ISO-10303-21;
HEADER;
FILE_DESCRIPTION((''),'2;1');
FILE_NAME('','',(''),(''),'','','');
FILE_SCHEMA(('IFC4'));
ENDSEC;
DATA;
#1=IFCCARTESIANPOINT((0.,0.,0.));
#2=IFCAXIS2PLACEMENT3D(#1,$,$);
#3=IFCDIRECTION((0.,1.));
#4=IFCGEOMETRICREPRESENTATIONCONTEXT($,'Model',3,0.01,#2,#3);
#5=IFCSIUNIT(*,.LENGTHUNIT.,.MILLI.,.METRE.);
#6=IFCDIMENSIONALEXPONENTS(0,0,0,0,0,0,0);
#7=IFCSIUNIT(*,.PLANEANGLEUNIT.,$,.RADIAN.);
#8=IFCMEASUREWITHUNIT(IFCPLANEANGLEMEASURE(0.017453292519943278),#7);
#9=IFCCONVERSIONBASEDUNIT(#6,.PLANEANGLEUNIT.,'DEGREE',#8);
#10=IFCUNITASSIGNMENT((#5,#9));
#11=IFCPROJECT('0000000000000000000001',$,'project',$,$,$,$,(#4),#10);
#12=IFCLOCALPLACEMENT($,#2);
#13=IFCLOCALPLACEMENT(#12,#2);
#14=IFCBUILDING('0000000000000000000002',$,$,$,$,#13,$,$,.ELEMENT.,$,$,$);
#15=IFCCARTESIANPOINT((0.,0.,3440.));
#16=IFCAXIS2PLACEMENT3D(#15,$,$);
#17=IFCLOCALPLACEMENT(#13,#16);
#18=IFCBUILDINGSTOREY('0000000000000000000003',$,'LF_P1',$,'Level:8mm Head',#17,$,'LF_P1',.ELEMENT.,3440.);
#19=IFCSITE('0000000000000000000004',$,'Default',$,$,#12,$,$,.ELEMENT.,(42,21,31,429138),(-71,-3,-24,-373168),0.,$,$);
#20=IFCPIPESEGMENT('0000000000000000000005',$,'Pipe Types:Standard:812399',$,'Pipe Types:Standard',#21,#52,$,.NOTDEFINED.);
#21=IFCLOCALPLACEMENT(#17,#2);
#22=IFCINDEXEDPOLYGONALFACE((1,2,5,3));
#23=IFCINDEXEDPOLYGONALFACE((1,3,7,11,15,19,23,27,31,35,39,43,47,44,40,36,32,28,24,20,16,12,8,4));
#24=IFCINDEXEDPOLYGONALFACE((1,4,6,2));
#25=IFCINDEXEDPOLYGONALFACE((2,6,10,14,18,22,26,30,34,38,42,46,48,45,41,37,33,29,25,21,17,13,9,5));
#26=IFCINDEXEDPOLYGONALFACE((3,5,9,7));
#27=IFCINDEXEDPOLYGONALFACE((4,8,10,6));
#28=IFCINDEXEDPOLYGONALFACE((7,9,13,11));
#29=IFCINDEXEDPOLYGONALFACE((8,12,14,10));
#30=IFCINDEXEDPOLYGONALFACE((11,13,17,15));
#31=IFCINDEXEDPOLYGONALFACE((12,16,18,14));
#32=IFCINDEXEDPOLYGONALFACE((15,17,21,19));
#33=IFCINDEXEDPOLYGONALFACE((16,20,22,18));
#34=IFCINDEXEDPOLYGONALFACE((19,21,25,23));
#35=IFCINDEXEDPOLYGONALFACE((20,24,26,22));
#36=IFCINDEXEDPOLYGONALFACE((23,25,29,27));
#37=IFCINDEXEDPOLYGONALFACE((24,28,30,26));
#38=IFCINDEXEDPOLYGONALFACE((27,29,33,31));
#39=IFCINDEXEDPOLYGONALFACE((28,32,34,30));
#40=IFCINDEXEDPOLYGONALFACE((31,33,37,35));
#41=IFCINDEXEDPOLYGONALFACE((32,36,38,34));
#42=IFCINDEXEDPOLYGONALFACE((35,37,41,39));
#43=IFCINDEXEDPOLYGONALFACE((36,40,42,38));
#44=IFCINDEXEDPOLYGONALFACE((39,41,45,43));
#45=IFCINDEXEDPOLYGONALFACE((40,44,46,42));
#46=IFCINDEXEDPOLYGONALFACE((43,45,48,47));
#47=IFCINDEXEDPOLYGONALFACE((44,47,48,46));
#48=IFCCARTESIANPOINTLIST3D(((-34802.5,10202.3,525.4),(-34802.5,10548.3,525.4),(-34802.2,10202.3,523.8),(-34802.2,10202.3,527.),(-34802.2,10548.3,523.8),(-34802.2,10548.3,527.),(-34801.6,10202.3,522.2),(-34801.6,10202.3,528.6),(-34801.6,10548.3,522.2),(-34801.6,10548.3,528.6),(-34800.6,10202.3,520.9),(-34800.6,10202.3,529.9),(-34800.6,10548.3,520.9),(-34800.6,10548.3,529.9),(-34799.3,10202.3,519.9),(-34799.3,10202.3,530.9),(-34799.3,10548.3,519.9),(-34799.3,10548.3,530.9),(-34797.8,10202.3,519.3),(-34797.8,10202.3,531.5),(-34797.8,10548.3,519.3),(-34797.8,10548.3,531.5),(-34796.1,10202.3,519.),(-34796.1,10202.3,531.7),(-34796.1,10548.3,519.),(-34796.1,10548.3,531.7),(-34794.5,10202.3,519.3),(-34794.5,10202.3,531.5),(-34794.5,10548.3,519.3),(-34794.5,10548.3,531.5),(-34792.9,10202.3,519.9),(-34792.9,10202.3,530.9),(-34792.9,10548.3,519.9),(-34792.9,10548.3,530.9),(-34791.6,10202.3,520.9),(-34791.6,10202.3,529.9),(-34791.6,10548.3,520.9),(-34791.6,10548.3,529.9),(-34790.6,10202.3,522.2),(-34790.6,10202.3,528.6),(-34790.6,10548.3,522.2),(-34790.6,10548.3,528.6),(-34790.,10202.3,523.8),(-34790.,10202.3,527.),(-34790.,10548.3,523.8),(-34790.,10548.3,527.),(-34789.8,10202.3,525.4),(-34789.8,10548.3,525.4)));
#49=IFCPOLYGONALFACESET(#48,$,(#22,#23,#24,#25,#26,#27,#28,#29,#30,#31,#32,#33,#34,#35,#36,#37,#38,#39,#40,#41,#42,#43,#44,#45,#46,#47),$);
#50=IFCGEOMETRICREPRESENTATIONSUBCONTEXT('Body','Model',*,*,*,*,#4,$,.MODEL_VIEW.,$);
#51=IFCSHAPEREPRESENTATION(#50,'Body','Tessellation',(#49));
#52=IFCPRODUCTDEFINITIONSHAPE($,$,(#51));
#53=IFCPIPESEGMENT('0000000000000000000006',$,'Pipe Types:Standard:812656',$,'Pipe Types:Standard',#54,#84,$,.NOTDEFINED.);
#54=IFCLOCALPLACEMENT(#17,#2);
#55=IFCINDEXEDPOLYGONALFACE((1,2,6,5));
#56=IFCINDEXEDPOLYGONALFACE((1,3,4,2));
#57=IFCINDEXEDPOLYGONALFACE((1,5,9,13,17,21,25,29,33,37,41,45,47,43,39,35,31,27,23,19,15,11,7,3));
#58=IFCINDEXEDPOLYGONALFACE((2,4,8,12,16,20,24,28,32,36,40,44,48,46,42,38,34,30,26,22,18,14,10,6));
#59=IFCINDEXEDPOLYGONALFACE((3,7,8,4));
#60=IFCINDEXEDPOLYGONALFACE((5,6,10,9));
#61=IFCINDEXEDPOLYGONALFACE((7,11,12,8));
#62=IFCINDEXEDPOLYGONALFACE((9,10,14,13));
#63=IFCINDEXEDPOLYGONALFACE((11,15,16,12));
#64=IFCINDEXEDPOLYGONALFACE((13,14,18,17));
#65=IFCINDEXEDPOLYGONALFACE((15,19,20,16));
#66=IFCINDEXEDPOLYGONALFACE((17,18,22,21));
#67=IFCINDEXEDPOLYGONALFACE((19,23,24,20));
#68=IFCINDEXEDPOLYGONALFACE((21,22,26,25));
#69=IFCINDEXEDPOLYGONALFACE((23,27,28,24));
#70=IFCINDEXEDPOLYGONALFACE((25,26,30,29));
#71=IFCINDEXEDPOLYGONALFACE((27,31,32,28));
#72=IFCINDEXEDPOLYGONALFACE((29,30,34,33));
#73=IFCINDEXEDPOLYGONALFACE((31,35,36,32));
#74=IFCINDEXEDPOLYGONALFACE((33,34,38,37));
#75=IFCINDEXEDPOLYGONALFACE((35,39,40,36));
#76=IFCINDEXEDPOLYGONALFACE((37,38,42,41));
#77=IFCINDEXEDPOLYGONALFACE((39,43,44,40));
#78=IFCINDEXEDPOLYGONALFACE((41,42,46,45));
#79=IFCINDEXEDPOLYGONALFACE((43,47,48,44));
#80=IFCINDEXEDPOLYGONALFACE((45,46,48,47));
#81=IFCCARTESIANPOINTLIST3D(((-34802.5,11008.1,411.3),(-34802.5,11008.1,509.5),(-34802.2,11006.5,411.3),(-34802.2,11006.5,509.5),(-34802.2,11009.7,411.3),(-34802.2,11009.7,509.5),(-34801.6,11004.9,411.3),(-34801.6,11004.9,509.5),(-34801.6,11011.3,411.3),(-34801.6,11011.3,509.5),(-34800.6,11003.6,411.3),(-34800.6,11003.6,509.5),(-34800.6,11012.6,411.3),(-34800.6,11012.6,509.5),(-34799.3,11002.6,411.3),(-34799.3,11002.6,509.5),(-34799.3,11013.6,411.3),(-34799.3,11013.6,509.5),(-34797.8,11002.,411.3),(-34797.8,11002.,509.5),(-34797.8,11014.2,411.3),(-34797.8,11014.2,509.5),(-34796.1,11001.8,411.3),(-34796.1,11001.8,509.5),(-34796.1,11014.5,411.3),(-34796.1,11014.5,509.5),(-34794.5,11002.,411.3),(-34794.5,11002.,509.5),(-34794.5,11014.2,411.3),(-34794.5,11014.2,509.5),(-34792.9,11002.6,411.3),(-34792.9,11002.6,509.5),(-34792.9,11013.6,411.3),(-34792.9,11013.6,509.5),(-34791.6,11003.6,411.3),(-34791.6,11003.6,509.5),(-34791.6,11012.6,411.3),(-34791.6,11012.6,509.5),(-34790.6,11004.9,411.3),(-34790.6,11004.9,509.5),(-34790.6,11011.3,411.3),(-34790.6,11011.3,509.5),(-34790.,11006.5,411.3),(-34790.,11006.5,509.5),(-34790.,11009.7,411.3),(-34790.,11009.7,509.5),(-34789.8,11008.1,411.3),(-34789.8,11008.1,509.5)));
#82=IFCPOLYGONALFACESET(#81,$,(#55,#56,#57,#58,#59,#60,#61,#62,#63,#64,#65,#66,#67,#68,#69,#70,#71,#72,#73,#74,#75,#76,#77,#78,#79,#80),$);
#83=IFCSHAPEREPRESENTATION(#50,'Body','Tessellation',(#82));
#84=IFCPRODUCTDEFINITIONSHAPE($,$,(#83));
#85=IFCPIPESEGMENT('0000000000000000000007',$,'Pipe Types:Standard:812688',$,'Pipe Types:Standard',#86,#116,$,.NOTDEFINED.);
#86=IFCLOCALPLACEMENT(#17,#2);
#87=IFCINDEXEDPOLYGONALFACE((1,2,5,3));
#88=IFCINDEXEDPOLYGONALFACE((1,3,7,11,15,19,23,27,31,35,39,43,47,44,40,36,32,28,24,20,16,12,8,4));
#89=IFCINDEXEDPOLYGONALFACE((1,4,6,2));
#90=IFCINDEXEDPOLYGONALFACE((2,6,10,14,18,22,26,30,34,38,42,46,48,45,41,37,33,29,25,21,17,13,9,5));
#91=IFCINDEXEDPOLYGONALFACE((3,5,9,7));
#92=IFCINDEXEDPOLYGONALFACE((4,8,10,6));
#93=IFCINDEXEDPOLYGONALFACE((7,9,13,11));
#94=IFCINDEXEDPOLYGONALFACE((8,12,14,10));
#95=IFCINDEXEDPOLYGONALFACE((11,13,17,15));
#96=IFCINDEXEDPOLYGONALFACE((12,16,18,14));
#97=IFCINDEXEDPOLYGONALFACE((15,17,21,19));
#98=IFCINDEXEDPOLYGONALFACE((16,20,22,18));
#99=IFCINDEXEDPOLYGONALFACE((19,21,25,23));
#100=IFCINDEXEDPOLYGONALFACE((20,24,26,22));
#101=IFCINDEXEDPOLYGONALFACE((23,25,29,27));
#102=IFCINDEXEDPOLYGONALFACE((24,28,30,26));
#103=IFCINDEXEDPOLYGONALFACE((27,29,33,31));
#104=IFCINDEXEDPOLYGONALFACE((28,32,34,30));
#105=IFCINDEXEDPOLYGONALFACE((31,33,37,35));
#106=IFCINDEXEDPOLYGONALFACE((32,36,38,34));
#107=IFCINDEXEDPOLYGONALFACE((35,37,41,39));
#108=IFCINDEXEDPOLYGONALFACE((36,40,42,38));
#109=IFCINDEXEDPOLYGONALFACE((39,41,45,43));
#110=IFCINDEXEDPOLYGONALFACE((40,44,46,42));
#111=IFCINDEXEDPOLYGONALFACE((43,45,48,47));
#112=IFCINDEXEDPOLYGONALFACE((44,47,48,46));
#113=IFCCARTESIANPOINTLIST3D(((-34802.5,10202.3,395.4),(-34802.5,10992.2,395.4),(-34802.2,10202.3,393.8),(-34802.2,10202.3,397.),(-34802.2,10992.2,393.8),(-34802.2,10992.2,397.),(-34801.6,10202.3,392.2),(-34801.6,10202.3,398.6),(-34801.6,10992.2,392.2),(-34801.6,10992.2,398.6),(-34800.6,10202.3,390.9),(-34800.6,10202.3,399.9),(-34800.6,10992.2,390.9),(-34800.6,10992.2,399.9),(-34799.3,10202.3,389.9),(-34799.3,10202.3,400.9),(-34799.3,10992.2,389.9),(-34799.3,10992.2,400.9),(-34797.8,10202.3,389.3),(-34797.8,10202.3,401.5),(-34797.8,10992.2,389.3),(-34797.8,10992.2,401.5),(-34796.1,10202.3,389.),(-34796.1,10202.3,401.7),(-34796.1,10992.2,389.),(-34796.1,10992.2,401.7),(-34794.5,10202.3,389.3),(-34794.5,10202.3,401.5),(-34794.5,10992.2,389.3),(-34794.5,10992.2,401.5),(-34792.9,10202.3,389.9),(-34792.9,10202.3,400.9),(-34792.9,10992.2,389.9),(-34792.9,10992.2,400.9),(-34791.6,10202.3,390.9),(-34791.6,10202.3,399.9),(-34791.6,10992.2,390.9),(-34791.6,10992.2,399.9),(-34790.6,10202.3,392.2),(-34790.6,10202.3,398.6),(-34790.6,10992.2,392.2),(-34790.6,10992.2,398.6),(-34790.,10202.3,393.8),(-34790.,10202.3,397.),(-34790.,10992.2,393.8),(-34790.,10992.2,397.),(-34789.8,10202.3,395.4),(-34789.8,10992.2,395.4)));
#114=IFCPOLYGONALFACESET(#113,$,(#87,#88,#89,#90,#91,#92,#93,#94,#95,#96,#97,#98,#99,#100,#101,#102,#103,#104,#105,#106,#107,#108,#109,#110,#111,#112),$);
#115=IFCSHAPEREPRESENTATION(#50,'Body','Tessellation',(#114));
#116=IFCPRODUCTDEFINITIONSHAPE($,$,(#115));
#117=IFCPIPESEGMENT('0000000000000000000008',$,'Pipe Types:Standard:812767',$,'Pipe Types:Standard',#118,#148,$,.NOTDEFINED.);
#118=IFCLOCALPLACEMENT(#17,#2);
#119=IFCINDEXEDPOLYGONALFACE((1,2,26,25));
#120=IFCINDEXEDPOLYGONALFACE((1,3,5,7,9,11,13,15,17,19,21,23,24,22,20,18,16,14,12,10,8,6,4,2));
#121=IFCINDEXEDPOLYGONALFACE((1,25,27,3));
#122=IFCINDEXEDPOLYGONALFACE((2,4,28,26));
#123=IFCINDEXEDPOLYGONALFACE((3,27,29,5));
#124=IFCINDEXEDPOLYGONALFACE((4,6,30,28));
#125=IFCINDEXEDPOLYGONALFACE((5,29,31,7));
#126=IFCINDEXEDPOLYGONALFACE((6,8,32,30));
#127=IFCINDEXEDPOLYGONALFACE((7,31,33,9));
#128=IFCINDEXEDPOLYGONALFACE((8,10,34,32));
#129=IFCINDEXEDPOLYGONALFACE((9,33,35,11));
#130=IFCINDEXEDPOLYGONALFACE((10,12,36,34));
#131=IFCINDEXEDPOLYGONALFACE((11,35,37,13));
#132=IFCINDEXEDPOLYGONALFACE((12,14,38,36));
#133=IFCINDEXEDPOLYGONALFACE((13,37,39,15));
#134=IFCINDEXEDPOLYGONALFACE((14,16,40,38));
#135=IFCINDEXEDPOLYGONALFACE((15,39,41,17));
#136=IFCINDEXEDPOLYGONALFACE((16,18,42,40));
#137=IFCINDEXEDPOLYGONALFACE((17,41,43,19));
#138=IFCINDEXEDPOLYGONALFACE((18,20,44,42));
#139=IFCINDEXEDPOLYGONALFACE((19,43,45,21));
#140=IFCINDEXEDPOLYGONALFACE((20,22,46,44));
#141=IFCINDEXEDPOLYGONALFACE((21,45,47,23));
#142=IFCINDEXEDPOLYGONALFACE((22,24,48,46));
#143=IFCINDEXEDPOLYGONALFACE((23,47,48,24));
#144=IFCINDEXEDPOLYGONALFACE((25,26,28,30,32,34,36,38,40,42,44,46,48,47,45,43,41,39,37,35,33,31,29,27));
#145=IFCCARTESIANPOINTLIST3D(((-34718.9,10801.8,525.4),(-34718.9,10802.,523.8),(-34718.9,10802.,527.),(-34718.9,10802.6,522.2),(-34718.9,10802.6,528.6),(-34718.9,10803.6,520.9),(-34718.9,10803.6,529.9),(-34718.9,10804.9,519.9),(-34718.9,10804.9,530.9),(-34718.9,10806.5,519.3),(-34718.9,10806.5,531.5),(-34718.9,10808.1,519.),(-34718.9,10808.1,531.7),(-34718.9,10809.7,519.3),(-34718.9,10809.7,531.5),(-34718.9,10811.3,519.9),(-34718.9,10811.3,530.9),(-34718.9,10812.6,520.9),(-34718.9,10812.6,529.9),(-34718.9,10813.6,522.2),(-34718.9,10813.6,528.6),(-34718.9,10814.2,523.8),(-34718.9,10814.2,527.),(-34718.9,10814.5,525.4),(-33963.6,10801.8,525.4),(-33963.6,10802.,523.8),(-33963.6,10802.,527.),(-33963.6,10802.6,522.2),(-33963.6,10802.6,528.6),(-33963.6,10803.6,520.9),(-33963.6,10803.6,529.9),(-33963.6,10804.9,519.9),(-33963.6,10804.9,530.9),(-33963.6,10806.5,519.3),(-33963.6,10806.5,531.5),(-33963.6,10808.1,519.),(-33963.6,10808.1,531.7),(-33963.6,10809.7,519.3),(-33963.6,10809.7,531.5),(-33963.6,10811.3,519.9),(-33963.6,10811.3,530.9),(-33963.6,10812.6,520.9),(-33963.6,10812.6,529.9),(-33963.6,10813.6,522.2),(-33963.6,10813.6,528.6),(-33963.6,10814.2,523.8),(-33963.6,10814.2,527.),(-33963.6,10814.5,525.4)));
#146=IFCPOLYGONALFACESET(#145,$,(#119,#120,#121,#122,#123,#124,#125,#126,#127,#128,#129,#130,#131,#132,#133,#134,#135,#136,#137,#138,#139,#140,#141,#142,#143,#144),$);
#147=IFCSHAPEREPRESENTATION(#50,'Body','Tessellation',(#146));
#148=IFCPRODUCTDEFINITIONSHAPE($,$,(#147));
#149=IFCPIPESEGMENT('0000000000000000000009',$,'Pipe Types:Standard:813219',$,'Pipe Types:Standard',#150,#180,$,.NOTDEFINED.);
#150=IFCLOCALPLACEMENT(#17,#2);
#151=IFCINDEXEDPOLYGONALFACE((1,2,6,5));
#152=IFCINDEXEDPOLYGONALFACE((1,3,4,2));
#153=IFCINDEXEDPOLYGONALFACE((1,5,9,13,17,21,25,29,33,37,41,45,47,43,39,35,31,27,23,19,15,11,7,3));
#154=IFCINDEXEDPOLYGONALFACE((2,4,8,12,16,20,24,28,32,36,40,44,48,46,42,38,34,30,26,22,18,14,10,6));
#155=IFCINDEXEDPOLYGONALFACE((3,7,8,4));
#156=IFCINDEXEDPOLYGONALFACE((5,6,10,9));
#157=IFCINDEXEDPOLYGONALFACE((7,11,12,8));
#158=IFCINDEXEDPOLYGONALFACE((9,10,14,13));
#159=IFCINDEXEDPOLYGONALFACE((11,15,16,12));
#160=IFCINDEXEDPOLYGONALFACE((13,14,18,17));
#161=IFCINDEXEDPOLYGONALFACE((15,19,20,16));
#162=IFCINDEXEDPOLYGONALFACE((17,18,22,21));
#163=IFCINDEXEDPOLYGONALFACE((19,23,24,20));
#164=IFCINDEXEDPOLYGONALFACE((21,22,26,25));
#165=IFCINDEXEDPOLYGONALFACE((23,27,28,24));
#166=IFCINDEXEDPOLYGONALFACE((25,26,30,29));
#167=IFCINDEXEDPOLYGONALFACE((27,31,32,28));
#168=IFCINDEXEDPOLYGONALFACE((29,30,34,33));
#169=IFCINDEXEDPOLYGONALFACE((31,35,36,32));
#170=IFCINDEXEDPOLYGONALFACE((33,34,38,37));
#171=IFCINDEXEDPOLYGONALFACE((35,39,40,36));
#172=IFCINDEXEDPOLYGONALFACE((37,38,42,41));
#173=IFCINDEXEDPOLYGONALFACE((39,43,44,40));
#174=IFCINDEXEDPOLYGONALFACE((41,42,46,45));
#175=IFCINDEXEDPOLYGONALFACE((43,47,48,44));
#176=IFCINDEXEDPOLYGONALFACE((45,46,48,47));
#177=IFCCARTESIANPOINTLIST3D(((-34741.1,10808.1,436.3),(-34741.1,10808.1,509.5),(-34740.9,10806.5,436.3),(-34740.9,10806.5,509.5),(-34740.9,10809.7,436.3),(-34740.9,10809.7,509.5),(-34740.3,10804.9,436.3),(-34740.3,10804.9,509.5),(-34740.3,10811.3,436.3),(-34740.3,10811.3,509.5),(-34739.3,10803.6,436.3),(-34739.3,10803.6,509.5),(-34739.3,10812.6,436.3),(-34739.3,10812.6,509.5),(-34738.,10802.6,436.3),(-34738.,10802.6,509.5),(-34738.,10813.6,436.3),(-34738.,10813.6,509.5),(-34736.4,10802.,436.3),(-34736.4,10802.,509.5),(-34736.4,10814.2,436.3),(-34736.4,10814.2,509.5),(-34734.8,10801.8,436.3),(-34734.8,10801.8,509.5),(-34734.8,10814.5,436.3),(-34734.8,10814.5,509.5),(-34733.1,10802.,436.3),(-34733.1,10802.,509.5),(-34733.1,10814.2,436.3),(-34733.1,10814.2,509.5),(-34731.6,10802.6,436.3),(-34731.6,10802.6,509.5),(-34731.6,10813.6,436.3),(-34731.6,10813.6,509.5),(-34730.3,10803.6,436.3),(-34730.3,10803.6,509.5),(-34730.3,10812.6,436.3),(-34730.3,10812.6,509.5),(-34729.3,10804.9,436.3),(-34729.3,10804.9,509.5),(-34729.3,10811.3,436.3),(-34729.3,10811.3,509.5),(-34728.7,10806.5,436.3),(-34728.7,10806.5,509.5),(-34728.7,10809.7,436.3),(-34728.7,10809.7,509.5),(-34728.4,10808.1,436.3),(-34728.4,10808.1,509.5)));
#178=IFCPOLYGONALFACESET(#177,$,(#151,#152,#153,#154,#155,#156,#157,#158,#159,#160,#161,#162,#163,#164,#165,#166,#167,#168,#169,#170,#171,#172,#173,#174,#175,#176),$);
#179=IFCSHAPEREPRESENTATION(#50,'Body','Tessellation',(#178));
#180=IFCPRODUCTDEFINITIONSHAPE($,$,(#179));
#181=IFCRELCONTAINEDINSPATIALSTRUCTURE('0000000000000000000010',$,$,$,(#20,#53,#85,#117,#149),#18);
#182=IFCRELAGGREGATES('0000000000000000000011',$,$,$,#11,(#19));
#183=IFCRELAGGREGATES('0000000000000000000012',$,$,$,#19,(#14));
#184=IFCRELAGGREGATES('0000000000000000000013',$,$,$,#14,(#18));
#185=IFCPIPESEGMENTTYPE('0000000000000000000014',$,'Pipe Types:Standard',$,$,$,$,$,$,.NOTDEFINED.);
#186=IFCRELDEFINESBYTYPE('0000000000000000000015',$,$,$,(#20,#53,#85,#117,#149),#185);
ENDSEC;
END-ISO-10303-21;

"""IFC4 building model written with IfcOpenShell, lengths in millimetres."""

from ifc_helpers import new_model, entity, si_unit, converted_unit, direction, frame, origin, place, context, subcontext, project, spatial, arc, indexed_curve, outline, extrude, type_object, element, save


model = new_model("IFC4")

# Units and contexts
model_context = context("Model", 3, precision=0.01, world=origin(), true_north=direction((0.0, 1.0)))
body_context = subcontext(model_context, "Body", "Model", "MODEL_VIEW")
ifc_project = project(units=[si_unit("LENGTHUNIT", "METRE", prefix="MILLI"), converted_unit("PLANEANGLEUNIT", "DEGREE", entity("IfcPlaneAngleMeasure", 0.017453292519943278), si_unit("PLANEANGLEUNIT", "RADIAN"), dimensions=[0, 0, 0, 0, 0, 0, 0])], contexts=[model_context])

# Site, building, storey
site_placement = place(None, origin())
site = spatial("IfcSite", under=ifc_project, at=site_placement, Name="Default", CompositionType="ELEMENT", RefLatitude=(42, 21, 31, 429138), RefLongitude=(-71, -3, -24, -373168), RefElevation=0.0)
building_placement = place(site_placement, origin())
building = spatial("IfcBuilding", under=site, at=building_placement, CompositionType="ELEMENT")
storey_placement = place(building_placement, frame((0.0, 0.0, 3440.0)))
storey = spatial("IfcBuildingStorey", under=building, at=storey_placement, Name="LF_P1", ObjectType="Level:8mm Head", LongName="LF_P1", CompositionType="ELEMENT", Elevation=3440.0)

# Pipe segments
pipe_segment_type_1 = type_object("IfcPipeSegmentType", Name="Pipe Types:Standard", PredefinedType="NOTDEFINED")
pipe_segment_1_placement = place(storey_placement, origin())
element("IfcPipeSegment", 1, at=pipe_segment_1_placement, inside=storey, type_object=pipe_segment_type_1, Name="Pipe Types:Standard:812399", ObjectType="Pipe Types:Standard", PredefinedType="NOTDEFINED", context=body_context, shape_type="SweptSolid", body=[
    extrude(outline(indexed_curve([(6.4, 0.0), (4.5, 4.5), (0.0, 6.4), (-4.5, 4.5), (-6.3, 0.0), (-4.5, -4.5), (0.0, -6.4), (4.5, -4.5)], segments=[arc(1, 2, 3), arc(3, 4, 5), arc(5, 6, 7), arc(7, 8, 1)], self_intersect=False)), frame((-34796.1, 10202.3, 525.4), z_axis=(0.0, 1.0, 0.0), x_axis=(-1.0, 0.0, 0.0)), (0.0, 0.0, 1.0), 346.0),
])
pipe_segment_2_placement = place(storey_placement, origin())
element("IfcPipeSegment", 2, at=pipe_segment_2_placement, inside=storey, type_object=pipe_segment_type_1, Name="Pipe Types:Standard:812656", ObjectType="Pipe Types:Standard", PredefinedType="NOTDEFINED", context=body_context, shape_type="SweptSolid", body=[
    extrude(outline(indexed_curve([(6.3, 0.0), (4.5, 4.5), (0.0, 6.4), (-4.5, 4.5), (-6.3, 0.0), (-4.5, -4.5), (0.0, -6.3), (4.5, -4.5)], segments=[arc(1, 2, 3), arc(3, 4, 5), arc(5, 6, 7), arc(7, 8, 1)], self_intersect=False)), frame((-34796.1, 11008.1, 411.3)), (0.0, 0.0, 1.0), 98.2),
])
pipe_segment_3_placement = place(storey_placement, origin())
element("IfcPipeSegment", 3, at=pipe_segment_3_placement, inside=storey, type_object=pipe_segment_type_1, Name="Pipe Types:Standard:812688", ObjectType="Pipe Types:Standard", PredefinedType="NOTDEFINED", context=body_context, shape_type="SweptSolid", body=[
    extrude(outline(indexed_curve([(6.4, 0.0), (4.5, 4.5), (0.0, 6.4), (-4.5, 4.5), (-6.3, 0.0), (-4.5, -4.5), (0.0, -6.3), (4.5, -4.5)], segments=[arc(1, 2, 3), arc(3, 4, 5), arc(5, 6, 7), arc(7, 8, 1)], self_intersect=False)), frame((-34796.1, 10202.3, 395.4), z_axis=(0.0, 1.0, 0.0), x_axis=(-1.0, 0.0, 0.0)), (0.0, 0.0, 1.0), 789.9),
])
pipe_segment_4_placement = place(storey_placement, origin())
element("IfcPipeSegment", 4, at=pipe_segment_4_placement, inside=storey, type_object=pipe_segment_type_1, Name="Pipe Types:Standard:812767", ObjectType="Pipe Types:Standard", PredefinedType="NOTDEFINED", context=body_context, shape_type="SweptSolid", body=[
    extrude(outline(indexed_curve([(6.3, 0.0), (4.5, 4.5), (0.0, 6.3), (-4.5, 4.5), (-6.4, 0.0), (-4.5, -4.5), (0.0, -6.4), (4.5, -4.5)], segments=[arc(1, 2, 3), arc(3, 4, 5), arc(5, 6, 7), arc(7, 8, 1)], self_intersect=False)), frame((-34718.9, 10808.1, 525.4), z_axis=(1.0, 0.0, 0.0), x_axis=(0.0, 1.0, 0.0)), (0.0, 0.0, 1.0), 755.3),
])
pipe_segment_5_placement = place(storey_placement, origin())
element("IfcPipeSegment", 5, at=pipe_segment_5_placement, inside=storey, type_object=pipe_segment_type_1, Name="Pipe Types:Standard:813219", ObjectType="Pipe Types:Standard", PredefinedType="NOTDEFINED", context=body_context, shape_type="SweptSolid", body=[
    extrude(outline(indexed_curve([(6.3, 0.0), (4.5, 4.5), (0.0, 6.4), (-4.5, 4.5), (-6.4, 0.0), (-4.5, -4.5), (0.0, -6.4), (4.5, -4.5)], segments=[arc(1, 2, 3), arc(3, 4, 5), arc(5, 6, 7), arc(7, 8, 1)], self_intersect=False)), frame((-34734.8, 10808.1, 436.3)), (0.0, 0.0, 1.0), 73.2),
])

save(model, "model.ifc")
